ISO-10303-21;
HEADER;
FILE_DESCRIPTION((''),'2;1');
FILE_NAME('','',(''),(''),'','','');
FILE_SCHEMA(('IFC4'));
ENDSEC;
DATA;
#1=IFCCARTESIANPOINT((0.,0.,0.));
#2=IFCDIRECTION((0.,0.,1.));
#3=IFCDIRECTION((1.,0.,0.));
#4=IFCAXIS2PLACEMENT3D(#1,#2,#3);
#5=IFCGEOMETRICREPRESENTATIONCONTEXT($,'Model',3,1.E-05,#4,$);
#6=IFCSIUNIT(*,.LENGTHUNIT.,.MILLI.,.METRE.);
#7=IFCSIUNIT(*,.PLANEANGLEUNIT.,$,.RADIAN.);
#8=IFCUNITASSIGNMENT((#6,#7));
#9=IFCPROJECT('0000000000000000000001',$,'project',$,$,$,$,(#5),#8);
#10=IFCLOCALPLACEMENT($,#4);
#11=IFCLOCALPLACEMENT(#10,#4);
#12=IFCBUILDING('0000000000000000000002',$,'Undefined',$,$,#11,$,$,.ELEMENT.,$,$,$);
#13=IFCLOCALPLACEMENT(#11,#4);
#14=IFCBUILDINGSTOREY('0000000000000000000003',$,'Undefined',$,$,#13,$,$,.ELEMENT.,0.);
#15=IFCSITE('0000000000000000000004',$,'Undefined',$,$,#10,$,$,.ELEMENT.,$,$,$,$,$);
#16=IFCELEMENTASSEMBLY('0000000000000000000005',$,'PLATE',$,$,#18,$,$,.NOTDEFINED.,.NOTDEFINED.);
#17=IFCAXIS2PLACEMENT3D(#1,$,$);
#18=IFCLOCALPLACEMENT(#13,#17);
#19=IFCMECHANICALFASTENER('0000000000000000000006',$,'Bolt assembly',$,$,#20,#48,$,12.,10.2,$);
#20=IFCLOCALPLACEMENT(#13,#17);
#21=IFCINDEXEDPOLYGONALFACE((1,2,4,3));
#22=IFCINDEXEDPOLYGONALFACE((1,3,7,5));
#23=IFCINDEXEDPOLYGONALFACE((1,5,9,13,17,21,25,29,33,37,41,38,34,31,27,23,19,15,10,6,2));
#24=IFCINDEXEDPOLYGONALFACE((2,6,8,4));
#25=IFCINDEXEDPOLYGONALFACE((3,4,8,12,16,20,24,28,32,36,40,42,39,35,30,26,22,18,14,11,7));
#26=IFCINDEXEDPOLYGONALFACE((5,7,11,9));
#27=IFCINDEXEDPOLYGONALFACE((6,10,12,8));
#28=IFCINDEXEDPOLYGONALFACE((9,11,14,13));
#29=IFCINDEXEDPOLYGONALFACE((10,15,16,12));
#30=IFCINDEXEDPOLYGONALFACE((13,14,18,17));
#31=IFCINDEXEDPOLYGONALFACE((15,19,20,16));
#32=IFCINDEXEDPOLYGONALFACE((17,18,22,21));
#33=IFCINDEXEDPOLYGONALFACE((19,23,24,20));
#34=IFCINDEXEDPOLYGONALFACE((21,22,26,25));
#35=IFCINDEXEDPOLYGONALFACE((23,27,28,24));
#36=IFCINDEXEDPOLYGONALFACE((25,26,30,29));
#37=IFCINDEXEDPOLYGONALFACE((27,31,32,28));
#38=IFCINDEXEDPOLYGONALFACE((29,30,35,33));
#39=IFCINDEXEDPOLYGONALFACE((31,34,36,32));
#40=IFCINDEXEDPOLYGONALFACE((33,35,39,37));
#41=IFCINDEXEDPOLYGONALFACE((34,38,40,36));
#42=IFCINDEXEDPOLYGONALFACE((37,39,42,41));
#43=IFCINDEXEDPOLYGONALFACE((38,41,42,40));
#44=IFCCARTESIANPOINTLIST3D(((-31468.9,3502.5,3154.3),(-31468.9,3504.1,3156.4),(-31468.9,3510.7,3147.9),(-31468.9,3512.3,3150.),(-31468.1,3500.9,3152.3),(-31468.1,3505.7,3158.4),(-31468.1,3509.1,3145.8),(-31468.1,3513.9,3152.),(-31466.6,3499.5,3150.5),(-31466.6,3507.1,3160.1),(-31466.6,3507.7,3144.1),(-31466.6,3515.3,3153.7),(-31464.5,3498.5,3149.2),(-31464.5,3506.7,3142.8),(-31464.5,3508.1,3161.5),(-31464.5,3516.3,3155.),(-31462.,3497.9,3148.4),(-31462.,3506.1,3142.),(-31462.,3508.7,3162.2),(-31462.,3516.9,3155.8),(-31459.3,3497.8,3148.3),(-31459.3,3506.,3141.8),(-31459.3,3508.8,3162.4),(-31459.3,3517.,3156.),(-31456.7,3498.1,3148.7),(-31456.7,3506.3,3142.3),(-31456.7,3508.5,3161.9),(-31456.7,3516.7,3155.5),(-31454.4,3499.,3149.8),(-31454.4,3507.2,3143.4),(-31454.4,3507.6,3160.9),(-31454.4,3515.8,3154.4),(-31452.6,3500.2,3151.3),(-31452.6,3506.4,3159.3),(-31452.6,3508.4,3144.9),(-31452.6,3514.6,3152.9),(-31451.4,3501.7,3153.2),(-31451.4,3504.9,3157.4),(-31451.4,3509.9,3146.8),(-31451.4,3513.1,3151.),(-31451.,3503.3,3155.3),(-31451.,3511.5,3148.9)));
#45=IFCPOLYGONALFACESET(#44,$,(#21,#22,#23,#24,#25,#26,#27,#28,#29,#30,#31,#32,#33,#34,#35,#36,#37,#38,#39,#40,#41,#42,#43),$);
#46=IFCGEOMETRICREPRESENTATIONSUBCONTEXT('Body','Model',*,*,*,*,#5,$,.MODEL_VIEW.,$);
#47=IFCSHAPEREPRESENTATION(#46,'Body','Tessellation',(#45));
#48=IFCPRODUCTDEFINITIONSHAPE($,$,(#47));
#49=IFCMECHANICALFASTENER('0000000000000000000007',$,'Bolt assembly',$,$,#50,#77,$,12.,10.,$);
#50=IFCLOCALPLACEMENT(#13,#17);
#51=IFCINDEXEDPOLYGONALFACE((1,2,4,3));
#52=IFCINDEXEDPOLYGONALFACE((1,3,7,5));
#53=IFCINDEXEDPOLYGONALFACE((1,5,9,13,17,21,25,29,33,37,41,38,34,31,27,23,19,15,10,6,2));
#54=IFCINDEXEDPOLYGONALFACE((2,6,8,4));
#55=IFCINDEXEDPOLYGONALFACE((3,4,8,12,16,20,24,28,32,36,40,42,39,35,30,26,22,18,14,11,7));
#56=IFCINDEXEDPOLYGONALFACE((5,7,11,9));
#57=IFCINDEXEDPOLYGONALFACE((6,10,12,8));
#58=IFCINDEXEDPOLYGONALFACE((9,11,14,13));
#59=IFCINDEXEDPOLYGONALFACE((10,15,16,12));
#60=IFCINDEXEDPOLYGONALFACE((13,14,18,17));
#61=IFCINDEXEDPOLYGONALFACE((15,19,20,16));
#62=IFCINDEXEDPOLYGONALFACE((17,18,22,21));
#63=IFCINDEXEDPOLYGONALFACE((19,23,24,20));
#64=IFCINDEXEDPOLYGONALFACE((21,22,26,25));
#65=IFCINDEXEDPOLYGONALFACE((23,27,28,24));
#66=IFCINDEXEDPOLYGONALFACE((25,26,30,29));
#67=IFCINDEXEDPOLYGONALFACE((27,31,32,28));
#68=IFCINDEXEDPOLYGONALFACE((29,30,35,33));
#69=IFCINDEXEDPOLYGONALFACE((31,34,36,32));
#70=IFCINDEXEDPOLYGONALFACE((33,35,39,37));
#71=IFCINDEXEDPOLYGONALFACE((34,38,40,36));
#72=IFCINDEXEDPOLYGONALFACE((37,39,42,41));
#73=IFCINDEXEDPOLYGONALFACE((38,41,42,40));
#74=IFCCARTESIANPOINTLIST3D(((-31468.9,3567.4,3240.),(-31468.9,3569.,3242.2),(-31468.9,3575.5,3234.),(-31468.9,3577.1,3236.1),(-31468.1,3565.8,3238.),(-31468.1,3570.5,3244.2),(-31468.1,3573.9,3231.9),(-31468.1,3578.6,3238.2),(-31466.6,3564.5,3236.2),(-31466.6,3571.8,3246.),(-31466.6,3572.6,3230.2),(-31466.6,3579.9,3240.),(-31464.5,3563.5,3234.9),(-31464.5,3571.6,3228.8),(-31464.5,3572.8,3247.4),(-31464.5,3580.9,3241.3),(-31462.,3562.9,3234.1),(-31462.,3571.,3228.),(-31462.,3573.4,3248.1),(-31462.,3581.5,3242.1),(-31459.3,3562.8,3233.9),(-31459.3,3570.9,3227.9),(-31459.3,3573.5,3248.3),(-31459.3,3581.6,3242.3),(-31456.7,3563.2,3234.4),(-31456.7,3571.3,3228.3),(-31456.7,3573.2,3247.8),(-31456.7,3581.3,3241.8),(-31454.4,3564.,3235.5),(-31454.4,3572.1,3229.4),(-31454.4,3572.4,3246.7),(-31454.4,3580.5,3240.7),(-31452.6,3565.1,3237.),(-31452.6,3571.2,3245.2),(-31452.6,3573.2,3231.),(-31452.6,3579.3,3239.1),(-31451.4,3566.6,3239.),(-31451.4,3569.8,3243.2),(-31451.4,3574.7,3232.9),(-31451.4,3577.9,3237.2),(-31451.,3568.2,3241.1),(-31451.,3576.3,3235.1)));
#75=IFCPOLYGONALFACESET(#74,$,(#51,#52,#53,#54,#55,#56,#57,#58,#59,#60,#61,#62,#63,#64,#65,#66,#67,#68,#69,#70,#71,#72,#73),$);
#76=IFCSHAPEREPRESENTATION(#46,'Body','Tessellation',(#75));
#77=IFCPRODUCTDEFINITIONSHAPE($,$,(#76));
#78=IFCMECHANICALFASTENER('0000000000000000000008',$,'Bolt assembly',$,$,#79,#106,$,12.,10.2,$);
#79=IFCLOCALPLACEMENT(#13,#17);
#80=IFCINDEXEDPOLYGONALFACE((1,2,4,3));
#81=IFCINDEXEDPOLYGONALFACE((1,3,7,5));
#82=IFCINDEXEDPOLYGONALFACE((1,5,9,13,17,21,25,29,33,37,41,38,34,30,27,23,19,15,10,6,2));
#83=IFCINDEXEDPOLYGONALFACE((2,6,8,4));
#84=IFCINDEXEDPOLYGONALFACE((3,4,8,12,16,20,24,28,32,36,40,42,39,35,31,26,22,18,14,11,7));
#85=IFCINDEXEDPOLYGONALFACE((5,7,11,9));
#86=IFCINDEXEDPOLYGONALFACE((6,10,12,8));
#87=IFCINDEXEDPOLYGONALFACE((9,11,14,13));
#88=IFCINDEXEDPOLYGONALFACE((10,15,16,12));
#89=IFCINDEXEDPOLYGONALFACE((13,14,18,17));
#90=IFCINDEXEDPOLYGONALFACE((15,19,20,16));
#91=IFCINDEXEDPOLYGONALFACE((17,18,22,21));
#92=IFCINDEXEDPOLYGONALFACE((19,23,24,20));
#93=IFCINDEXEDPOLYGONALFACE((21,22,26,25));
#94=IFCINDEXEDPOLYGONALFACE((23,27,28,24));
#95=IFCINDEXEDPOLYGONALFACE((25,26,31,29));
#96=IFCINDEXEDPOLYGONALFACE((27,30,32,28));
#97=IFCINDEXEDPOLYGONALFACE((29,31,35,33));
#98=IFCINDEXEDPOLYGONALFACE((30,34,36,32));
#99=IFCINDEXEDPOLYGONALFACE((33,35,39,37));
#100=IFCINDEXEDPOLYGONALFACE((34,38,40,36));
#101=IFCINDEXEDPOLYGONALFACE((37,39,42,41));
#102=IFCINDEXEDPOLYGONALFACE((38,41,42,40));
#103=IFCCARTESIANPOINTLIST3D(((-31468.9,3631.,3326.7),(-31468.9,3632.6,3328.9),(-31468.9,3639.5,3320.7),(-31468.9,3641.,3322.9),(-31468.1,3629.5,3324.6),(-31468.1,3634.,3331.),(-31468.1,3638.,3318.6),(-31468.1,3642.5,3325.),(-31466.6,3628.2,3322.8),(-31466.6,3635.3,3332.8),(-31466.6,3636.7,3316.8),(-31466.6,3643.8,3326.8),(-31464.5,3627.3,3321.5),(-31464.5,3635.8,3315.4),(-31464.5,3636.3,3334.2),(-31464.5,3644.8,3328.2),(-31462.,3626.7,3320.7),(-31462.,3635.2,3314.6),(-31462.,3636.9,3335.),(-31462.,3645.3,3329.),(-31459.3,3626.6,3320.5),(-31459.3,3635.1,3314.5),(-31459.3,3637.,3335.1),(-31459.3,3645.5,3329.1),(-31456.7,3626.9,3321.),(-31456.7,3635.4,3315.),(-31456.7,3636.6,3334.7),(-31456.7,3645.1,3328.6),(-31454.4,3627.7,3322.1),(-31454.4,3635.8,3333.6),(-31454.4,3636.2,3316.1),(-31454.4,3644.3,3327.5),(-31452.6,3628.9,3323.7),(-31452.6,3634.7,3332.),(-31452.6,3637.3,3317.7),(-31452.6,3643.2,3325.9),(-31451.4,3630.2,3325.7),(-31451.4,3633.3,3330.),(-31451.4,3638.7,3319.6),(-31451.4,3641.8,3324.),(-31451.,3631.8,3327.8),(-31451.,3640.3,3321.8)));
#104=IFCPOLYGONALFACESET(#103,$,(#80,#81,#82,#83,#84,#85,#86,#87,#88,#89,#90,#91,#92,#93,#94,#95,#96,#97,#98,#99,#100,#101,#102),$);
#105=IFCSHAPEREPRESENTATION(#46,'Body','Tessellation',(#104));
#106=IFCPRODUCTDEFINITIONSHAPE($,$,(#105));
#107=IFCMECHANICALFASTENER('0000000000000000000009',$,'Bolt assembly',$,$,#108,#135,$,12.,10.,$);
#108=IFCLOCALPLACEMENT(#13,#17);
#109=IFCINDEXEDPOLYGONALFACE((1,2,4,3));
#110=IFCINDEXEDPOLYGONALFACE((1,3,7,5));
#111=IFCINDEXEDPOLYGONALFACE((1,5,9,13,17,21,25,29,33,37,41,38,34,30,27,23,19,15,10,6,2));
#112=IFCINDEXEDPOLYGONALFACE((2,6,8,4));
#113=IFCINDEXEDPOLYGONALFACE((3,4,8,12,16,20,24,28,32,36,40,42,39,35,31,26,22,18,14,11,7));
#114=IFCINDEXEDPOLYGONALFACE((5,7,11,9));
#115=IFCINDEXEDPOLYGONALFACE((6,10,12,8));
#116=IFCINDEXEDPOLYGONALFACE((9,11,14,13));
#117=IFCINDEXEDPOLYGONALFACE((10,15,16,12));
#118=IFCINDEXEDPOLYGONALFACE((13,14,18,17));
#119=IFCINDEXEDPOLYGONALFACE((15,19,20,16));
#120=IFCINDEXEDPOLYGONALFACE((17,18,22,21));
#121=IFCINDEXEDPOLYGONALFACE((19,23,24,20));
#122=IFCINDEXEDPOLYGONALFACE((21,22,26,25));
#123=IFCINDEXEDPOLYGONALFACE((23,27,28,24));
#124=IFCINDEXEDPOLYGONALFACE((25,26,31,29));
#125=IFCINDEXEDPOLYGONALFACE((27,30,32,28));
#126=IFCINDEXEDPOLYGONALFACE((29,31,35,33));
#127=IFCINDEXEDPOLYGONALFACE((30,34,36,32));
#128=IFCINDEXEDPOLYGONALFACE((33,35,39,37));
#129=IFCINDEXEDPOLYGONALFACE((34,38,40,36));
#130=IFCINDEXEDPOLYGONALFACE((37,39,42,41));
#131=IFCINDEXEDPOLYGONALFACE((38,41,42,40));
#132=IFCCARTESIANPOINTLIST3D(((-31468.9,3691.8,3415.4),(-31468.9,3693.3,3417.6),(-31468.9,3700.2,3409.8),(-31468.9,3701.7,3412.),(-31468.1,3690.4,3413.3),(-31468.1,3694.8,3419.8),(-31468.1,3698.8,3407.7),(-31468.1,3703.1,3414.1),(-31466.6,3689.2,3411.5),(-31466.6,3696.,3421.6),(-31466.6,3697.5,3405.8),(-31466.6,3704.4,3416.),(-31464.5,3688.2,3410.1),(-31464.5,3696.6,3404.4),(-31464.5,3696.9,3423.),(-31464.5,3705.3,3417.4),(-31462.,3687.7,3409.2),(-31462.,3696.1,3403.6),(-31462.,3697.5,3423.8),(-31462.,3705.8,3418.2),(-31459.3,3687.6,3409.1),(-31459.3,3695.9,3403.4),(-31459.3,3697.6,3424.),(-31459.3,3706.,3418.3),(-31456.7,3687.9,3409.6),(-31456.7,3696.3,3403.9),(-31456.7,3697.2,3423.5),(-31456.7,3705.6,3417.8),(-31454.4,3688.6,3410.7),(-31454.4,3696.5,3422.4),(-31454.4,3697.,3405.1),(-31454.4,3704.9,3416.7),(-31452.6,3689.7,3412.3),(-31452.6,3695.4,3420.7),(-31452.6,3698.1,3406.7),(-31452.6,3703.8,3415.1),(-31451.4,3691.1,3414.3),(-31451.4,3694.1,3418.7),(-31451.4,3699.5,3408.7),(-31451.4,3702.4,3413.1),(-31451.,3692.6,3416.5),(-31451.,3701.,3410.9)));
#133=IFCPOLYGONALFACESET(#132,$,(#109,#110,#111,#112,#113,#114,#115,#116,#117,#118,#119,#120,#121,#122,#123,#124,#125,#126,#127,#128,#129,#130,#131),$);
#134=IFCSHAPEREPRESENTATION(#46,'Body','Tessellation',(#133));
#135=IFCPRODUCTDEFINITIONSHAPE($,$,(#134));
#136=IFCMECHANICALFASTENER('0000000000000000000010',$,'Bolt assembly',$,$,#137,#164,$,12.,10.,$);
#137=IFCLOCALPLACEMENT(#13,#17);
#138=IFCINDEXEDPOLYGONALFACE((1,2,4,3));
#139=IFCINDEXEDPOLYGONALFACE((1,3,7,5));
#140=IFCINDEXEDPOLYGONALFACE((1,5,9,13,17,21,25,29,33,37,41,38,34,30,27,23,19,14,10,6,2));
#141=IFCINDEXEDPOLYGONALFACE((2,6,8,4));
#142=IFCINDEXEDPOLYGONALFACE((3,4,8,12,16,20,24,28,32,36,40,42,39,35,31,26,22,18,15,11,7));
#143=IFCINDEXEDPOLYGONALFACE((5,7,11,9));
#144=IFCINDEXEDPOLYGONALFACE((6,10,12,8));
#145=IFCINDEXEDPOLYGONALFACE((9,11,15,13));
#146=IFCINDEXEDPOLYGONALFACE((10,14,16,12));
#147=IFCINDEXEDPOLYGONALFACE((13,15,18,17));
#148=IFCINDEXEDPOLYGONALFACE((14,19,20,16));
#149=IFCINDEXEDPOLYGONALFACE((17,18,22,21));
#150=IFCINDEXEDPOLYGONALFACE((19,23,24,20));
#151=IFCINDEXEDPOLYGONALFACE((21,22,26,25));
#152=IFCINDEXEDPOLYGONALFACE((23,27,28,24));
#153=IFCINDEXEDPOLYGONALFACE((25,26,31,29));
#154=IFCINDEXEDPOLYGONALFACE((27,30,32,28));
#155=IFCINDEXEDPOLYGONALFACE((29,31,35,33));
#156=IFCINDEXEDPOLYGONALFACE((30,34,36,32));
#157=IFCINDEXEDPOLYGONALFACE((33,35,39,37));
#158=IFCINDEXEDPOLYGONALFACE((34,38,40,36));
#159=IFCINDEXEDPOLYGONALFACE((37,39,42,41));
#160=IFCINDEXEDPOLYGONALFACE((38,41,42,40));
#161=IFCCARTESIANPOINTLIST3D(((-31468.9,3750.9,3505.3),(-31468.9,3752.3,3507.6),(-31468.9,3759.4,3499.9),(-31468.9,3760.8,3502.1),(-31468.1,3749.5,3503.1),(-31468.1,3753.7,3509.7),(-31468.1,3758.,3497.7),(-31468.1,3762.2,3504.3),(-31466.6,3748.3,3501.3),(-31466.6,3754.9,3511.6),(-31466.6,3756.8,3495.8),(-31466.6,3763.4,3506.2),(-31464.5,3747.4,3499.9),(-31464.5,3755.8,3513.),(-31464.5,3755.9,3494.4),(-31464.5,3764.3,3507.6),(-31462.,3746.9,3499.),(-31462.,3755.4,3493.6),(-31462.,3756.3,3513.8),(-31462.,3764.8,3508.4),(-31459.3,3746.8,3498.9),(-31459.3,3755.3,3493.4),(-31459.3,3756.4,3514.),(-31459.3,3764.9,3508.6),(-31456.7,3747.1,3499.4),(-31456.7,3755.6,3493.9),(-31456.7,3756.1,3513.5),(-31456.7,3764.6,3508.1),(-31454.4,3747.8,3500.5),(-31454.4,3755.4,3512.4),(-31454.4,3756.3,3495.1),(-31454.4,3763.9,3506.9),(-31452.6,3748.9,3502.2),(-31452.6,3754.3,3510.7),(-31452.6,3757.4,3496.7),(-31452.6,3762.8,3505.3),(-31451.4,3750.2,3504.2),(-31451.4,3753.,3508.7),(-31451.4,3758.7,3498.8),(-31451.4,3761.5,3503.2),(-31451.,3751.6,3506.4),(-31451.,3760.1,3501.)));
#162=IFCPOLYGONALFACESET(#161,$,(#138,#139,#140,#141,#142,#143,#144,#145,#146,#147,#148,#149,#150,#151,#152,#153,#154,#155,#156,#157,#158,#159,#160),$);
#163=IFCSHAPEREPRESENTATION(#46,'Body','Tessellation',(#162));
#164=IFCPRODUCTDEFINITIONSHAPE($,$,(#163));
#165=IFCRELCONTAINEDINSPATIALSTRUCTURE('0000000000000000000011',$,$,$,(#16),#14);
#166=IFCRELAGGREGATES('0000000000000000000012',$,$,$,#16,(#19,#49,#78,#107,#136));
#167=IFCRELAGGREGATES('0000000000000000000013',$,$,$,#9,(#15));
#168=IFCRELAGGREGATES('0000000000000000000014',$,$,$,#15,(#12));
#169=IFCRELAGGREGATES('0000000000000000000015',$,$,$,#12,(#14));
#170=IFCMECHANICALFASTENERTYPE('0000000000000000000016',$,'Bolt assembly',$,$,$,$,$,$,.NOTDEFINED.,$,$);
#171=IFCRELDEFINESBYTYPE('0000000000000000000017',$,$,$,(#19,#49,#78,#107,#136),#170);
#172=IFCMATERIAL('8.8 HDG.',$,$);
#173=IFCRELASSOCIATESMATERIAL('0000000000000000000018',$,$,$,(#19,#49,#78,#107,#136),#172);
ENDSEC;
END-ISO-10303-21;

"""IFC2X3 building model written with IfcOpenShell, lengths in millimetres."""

from ifc_helpers import new_model, si_unit, frame, origin_with_axes, origin_2d_with_axis, place, context, subcontext, project, spatial, circle, extrude, source, transform, mapped, material, type_object, element, aggregate, save


model = new_model("IFC2X3")

# Units and contexts
model_context = context("Model", 3, precision=1e-05, world=origin_with_axes())
body_context = subcontext(model_context, "Body", "Model", "MODEL_VIEW")
ifc_project = project(units=[si_unit("LENGTHUNIT", "METRE", prefix="MILLI"), si_unit("PLANEANGLEUNIT", "RADIAN")], contexts=[model_context])

# Site, building, storey
site_placement = place(None, origin_with_axes())
site = spatial("IfcSite", under=ifc_project, at=site_placement, Name="Undefined", CompositionType="ELEMENT")
building_placement = place(site_placement, origin_with_axes())
building = spatial("IfcBuilding", under=site, at=building_placement, Name="Undefined", CompositionType="ELEMENT")
storey_placement = place(building_placement, origin_with_axes())
storey = spatial("IfcBuildingStorey", under=building, at=storey_placement, Name="Undefined", CompositionType="ELEMENT", Elevation=0.0)

# Element assembly, mechanical fasteners
assembly_placement = place(storey_placement, origin_with_axes())
assembly = element("IfcElementAssembly", 1, at=assembly_placement, inside=storey, Name="PLATE", AssemblyPlace="NOTDEFINED", PredefinedType="NOTDEFINED")
ifc_material_1 = material(Name="8.8 HDG.")
mechanical_fastener_type = type_object("IfcMechanicalFastenerType", Name="Bolt assembly")
shared_shape_1 = source(origin_with_axes(), body_context, "Body", "SweptSolid", [
    extrude(circle(Radius=9.0, at=origin_2d_with_axis()), frame((0.0, 0.1, 0.0), z_axis=(0.0, 1.0, 0.0), x_axis=(1.0, 0.0, 0.0)), (0.0, 0.0, 1.0), 10.4),
])
mechanical_fastener_1_placement = place(assembly_placement, frame((-31460.0, 3511.6, 3148.8), z_axis=(0.000001, -0.616719, -0.787183), x_axis=(1.0, 0.000001, 0.000001)))
mechanical_fastener_1 = element("IfcMechanicalFastener", 2, at=mechanical_fastener_1_placement, type_object=mechanical_fastener_type, material=ifc_material_1, Name="Bolt assembly", NominalDiameter=12.0, NominalLength=10.2, context=body_context, shape_type="MappedRepresentation", body=[
    mapped(shared_shape_1, transform((0.0, 0.0, 0.0))),
])
shared_shape_2 = source(origin_with_axes(), body_context, "Body", "SweptSolid", [
    extrude(circle(Radius=9.0, at=origin_2d_with_axis()), frame((0.0, 0.9, 0.0), z_axis=(0.0, 1.0, 0.0), x_axis=(1.0, 0.0, 0.0)), (0.0, 0.0, 1.0), 10.1),
])
mechanical_fastener_2_placement = place(assembly_placement, frame((-31460.0, 3577.0, 3234.5), z_axis=(0.000001, -0.597518, -0.801856), x_axis=(1.0, 0.000001, 0.000001)))
mechanical_fastener_2 = element("IfcMechanicalFastener", 3, at=mechanical_fastener_2_placement, type_object=mechanical_fastener_type, material=ifc_material_1, Name="Bolt assembly", NominalDiameter=12.0, NominalLength=10.0, context=body_context, shape_type="MappedRepresentation", body=[
    mapped(shared_shape_2, transform((0.0, 0.0, 0.0))),
])
shared_shape_3 = source(origin_with_axes(), body_context, "Body", "SweptSolid", [
    extrude(circle(Radius=9.0, at=origin_2d_with_axis()), frame((0.0, 0.2, 0.0), z_axis=(0.0, 1.0, 0.0), x_axis=(1.0, 0.0, 0.0)), (0.0, 0.0, 1.0), 10.4),
])
mechanical_fastener_3_placement = place(assembly_placement, frame((-31460.0, 3640.4, 3321.7), z_axis=(0.000001, -0.577967, -0.81606), x_axis=(1.0, 0.000001, 0.000001)))
mechanical_fastener_3 = element("IfcMechanicalFastener", 4, at=mechanical_fastener_3_placement, type_object=mechanical_fastener_type, material=ifc_material_1, Name="Bolt assembly", NominalDiameter=12.0, NominalLength=10.2, context=body_context, shape_type="MappedRepresentation", body=[
    mapped(shared_shape_3, transform((0.0, 0.0, 0.0))),
])
shared_shape_4 = source(origin_with_axes(), body_context, "Body", "SweptSolid", [
    extrude(circle(Radius=9.0, at=origin_2d_with_axis()), frame((0.0, 0.8, 0.0), z_axis=(0.0, 1.0, 0.0), x_axis=(1.0, 0.0, 0.0)), (0.0, 0.0, 1.0), 10.1),
])
mechanical_fastener_4_placement = place(assembly_placement, frame((-31460.0, 3701.6, 3410.4), z_axis=(0.000001, -0.558079, -0.829788), x_axis=(1.0, 0.000001, 0.000001)))
mechanical_fastener_4 = element("IfcMechanicalFastener", 5, at=mechanical_fastener_4_placement, type_object=mechanical_fastener_type, material=ifc_material_1, Name="Bolt assembly", NominalDiameter=12.0, NominalLength=10.0, context=body_context, shape_type="MappedRepresentation", body=[
    mapped(shared_shape_4, transform((0.0, 0.0, 0.0))),
])
shared_shape_5 = source(origin_with_axes(), body_context, "Body", "SweptSolid", [
    extrude(circle(Radius=9.0, at=origin_2d_with_axis()), frame((0.0, 0.7, 0.0), z_axis=(0.0, 1.0, 0.0), x_axis=(1.0, 0.0, 0.0)), (0.0, 0.0, 1.0), 10.1),
])
mechanical_fastener_5_placement = place(assembly_placement, frame((-31460.0, 3760.7, 3500.6), z_axis=(0.000001, -0.537866, -0.843031), x_axis=(1.0, 0.000001, 0.000001)))
mechanical_fastener_5 = element("IfcMechanicalFastener", 6, at=mechanical_fastener_5_placement, type_object=mechanical_fastener_type, material=ifc_material_1, Name="Bolt assembly", NominalDiameter=12.0, NominalLength=10.0, context=body_context, shape_type="MappedRepresentation", body=[
    mapped(shared_shape_5, transform((0.0, 0.0, 0.0))),
])
aggregate(assembly, [mechanical_fastener_1, mechanical_fastener_2, mechanical_fastener_3, mechanical_fastener_4, mechanical_fastener_5])

save(model, "model.ifc")
